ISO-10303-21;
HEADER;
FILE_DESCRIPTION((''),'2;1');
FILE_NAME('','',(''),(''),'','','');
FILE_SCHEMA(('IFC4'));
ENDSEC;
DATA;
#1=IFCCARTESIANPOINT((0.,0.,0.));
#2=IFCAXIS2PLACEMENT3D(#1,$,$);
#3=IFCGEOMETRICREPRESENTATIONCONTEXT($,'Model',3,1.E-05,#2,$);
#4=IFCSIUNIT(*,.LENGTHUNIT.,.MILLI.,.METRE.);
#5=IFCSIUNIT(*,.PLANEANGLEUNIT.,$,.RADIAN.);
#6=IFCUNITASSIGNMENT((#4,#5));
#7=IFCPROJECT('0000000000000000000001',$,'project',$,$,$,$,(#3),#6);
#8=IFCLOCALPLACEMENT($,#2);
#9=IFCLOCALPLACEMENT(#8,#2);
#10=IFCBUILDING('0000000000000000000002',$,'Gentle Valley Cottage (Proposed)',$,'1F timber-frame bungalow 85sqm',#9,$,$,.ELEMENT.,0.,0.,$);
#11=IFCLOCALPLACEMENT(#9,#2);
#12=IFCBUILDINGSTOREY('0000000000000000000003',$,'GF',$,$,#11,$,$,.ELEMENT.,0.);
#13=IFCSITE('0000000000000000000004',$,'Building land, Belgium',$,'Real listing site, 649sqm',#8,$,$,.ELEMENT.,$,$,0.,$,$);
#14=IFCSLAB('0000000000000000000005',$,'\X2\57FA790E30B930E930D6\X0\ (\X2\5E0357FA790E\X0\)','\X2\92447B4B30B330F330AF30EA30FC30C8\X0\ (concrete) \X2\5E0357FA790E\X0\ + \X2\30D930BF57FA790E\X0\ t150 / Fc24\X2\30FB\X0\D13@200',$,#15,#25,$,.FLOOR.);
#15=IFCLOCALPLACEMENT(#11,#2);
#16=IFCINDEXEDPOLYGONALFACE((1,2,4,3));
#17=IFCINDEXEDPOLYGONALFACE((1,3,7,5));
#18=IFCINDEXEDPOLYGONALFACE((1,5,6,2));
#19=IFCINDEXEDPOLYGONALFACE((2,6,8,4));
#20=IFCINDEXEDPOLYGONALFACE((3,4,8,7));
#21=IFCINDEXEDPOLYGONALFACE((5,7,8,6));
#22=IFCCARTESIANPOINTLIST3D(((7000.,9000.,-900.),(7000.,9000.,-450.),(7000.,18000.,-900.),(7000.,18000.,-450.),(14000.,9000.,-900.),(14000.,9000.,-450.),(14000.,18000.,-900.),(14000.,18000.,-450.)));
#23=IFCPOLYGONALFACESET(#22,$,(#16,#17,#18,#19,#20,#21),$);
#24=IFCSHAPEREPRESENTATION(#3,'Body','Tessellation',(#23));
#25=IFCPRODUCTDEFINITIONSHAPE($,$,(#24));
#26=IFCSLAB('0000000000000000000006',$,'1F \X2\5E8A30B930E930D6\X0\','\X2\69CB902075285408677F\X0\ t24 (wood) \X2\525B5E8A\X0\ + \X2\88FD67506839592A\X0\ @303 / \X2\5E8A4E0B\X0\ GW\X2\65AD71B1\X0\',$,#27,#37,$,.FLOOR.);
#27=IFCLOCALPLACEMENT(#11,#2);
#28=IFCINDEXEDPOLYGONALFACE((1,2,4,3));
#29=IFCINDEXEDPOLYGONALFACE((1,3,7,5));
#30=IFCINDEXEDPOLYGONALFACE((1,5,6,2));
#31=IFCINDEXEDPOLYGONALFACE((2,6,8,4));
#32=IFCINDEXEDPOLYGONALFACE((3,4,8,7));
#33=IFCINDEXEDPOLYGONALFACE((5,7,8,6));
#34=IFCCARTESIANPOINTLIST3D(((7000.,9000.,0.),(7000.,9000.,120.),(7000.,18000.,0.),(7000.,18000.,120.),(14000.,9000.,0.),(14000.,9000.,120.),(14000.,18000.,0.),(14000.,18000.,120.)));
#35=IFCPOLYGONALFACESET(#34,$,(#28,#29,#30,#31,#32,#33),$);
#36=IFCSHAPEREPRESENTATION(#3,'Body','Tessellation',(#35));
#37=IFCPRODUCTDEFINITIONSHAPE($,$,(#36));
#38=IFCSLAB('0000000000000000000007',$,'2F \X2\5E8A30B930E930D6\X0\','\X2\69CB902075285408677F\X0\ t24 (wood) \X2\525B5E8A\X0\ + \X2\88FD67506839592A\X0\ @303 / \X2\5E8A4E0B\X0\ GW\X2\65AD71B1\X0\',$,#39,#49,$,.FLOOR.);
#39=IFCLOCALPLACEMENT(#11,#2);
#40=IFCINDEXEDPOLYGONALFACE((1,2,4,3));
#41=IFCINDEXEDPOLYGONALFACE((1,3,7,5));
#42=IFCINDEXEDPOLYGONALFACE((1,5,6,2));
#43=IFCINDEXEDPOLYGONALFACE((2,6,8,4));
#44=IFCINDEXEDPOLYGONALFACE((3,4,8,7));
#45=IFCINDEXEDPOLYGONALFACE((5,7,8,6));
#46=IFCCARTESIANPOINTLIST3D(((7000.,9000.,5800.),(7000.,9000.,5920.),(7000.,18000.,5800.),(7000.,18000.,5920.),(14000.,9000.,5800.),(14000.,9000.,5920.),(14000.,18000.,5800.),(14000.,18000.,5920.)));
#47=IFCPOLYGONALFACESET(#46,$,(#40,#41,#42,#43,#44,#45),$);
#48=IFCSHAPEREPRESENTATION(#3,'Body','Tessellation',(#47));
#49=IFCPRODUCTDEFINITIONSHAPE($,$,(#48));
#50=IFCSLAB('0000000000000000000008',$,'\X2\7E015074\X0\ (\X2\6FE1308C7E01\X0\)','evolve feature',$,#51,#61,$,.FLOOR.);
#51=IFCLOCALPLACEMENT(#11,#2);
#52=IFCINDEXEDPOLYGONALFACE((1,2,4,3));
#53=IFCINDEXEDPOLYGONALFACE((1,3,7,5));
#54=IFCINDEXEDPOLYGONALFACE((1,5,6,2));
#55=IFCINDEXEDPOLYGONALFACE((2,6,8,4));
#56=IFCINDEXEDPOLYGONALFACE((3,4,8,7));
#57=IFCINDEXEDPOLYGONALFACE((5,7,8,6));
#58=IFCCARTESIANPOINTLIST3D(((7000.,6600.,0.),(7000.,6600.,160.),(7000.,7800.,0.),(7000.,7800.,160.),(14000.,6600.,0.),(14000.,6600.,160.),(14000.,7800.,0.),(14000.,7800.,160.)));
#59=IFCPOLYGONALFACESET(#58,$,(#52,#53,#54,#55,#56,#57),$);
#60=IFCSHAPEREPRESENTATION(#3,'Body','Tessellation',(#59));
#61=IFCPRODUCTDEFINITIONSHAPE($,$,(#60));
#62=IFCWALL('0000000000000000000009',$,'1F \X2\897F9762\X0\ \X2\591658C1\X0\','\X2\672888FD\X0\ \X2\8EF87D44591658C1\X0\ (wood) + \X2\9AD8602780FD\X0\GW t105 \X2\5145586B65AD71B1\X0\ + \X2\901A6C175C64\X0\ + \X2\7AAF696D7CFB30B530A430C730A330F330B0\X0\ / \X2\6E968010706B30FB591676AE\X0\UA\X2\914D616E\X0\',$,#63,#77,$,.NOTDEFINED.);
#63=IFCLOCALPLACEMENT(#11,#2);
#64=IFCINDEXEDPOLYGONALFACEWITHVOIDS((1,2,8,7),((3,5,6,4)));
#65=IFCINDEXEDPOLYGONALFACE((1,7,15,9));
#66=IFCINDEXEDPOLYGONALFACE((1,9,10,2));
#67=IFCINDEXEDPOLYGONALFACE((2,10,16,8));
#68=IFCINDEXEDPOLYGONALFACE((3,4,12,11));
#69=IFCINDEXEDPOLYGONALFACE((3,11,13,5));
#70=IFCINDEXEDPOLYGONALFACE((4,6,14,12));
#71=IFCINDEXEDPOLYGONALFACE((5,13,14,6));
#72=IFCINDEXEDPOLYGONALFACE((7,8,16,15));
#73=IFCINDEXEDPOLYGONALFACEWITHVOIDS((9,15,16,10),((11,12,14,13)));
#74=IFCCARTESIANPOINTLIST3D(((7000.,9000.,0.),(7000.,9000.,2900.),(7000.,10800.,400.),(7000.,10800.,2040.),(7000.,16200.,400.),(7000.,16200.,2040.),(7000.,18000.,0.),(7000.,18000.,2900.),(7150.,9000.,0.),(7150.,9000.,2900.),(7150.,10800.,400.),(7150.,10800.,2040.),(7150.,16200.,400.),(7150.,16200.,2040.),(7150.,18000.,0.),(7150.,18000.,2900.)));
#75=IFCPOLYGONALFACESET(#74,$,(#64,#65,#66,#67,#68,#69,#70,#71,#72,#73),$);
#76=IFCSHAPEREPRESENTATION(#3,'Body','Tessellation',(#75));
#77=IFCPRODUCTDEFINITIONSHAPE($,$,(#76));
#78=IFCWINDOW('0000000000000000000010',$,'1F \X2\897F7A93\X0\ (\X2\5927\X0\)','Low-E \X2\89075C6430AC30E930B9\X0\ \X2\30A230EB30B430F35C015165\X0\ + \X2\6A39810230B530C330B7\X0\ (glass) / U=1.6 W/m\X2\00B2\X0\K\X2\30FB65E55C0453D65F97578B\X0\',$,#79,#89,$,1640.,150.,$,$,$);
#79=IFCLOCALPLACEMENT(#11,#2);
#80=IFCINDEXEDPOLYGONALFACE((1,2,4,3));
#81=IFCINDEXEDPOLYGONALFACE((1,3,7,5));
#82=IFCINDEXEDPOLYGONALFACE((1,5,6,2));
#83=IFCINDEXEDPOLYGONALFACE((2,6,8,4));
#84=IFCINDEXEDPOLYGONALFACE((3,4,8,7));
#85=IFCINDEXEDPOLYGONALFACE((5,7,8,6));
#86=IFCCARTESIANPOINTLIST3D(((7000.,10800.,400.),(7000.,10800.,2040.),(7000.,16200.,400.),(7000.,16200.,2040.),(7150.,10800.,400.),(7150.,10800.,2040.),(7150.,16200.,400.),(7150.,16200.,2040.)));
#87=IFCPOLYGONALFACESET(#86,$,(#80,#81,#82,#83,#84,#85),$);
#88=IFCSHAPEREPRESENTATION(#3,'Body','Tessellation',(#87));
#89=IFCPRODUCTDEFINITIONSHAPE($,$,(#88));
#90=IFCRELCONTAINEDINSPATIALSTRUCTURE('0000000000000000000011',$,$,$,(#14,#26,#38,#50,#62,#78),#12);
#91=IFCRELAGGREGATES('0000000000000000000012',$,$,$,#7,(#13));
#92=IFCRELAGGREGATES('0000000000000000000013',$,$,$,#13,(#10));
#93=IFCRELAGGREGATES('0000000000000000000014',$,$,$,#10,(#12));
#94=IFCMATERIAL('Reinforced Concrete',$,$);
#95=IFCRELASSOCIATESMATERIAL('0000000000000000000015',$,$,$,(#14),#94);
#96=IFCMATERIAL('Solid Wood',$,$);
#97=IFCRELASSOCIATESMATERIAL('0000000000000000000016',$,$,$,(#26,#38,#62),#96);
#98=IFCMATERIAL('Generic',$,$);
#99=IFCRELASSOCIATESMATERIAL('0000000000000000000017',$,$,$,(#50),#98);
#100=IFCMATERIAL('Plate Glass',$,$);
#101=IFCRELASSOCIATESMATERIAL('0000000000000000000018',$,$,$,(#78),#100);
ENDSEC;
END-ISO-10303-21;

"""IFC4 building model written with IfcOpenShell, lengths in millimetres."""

from ifc_helpers import new_model, si_unit, frame, frame_2d, origin, place, context, project, spatial, rectangle, extrude, material, element, fill, save


model = new_model("IFC4")

# Units and contexts
model_context = context("Model", 3, precision=1e-05, world=origin())
ifc_project = project(units=[si_unit("LENGTHUNIT", "METRE", prefix="MILLI"), si_unit("PLANEANGLEUNIT", "RADIAN")], contexts=[model_context])

# Site, building, storey
site_placement = place(None, origin())
site = spatial("IfcSite", under=ifc_project, at=site_placement, Name="Building land, Belgium", ObjectType="Real listing site, 649sqm", CompositionType="ELEMENT", RefElevation=0.0)
building_placement = place(site_placement, origin())
building = spatial("IfcBuilding", under=site, at=building_placement, Name="Gentle Valley Cottage (Proposed)", ObjectType="1F timber-frame bungalow 85sqm", CompositionType="ELEMENT", ElevationOfRefHeight=0.0, ElevationOfTerrain=0.0)
storey_placement = place(building_placement, origin())
storey = spatial("IfcBuildingStorey", under=building, at=storey_placement, Name="GF", CompositionType="ELEMENT", Elevation=0.0)

# Slabs
ifc_material_1 = material(Name="Reinforced Concrete")
slab_1_placement = place(storey_placement, frame((3500.0, 4500.0, -450.0)))
element("IfcSlab", 1, at=slab_1_placement, inside=storey, material=ifc_material_1, Name="基礎スラブ (布基礎)", Description="鉄筋コンクリート (concrete) 布基礎 + ベタ基礎 t150 / Fc24・D13@200", PredefinedType="FLOOR", context=model_context, shape_type="SweptSolid", body=[
    extrude(rectangle(XDim=7000.0, YDim=9000.0, at=frame_2d((3500.0, 4500.0))), frame((3500.0, 4500.0, -450.0)), (0.0, 0.0, 1.0), 450.0),
])
ifc_material_2 = material(Name="Solid Wood")
slab_2_placement = place(storey_placement, frame((3500.0, 4500.0, 0.0)))
element("IfcSlab", 2, at=slab_2_placement, inside=storey, material=ifc_material_2, Name="1F 床スラブ", Description="構造用合板 t24 (wood) 剛床 + 製材根太 @303 / 床下 GW断熱", PredefinedType="FLOOR", context=model_context, shape_type="SweptSolid", body=[
    extrude(rectangle(XDim=7000.0, YDim=9000.0, at=frame_2d((3500.0, 4500.0))), frame((3500.0, 4500.0, 0.0)), (0.0, 0.0, 1.0), 120.0),
])
slab_3_placement = place(storey_placement, frame((3500.0, 4500.0, 2900.0)))
element("IfcSlab", 3, at=slab_3_placement, inside=storey, material=ifc_material_2, Name="2F 床スラブ", Description="構造用合板 t24 (wood) 剛床 + 製材根太 @303 / 床下 GW断熱", PredefinedType="FLOOR", context=model_context, shape_type="SweptSolid", body=[
    extrude(rectangle(XDim=7000.0, YDim=9000.0, at=frame_2d((3500.0, 4500.0))), frame((3500.0, 4500.0, 2900.0)), (0.0, 0.0, 1.0), 120.0),
])
ifc_material_3 = material(Name="Generic")
slab_4_placement = place(storey_placement, frame((3500.0, 3300.0, 0.0)))
element("IfcSlab", 4, at=slab_4_placement, inside=storey, material=ifc_material_3, Name="縁側 (濡れ縁)", Description="evolve feature", PredefinedType="FLOOR", context=model_context, shape_type="SweptSolid", body=[
    extrude(rectangle(XDim=7000.0, YDim=1200.0, at=frame_2d((3500.0, 600.0))), frame((3500.0, 3300.0, 0.0)), (0.0, 0.0, 1.0), 160.0),
])

# Shared definitions
ifc_material_4 = material(Name="Plate Glass")

# Wall, opening, window
wall_1_placement = place(storey_placement, frame((3500.0, 4500.0, 0.0)))
wall_1 = element("IfcWall", 5, at=wall_1_placement, inside=storey, material=ifc_material_2, Name="1F 西面 外壁", Description="木製 軸組外壁 (wood) + 高性能GW t105 充填断熱 + 通気層 + 窯業系サイディング / 準耐火・外皮UA配慮", PredefinedType="NOTDEFINED", context=model_context, shape_type="SweptSolid", body=[
    extrude(rectangle(XDim=150.0, YDim=9000.0, at=frame_2d((75.0, 4500.0))), frame((3500.0, 4500.0, 0.0)), (0.0, 0.0, 1.0), 2900.0),
])
opening_1_placement = place(storey_placement, frame((3500.0, 5400.0, 200.0)))
opening_1 = element("IfcOpeningElement", 6, at=opening_1_placement, cuts=wall_1, PredefinedType="NOTDEFINED", context=model_context, shape_type="SweptSolid", body=[
    extrude(rectangle(XDim=150.0, YDim=5400.0, at=frame_2d((75.0, 2700.0))), frame((3500.0, 5400.0, 200.0)), (0.0, 0.0, 1.0), 1640.0),
])
window_1_placement = place(storey_placement, frame((3500.0, 5400.0, 200.0)))
window_1 = element("IfcWindow", 7, at=window_1_placement, inside=storey, material=ifc_material_4, Name="1F 西窓 (大)", Description="Low-E 複層ガラス アルゴン封入 + 樹脂サッシ (glass) / U=1.6 W/m²K・日射取得型", OverallHeight=1640.0, OverallWidth=150.0, context=model_context, shape_type="SweptSolid", body=[
    extrude(rectangle(XDim=150.0, YDim=5400.0, at=frame_2d((75.0, 2700.0))), frame((3500.0, 5400.0, 200.0)), (0.0, 0.0, 1.0), 1640.0),
])
fill(opening_1, window_1)

save(model, "model.ifc")
